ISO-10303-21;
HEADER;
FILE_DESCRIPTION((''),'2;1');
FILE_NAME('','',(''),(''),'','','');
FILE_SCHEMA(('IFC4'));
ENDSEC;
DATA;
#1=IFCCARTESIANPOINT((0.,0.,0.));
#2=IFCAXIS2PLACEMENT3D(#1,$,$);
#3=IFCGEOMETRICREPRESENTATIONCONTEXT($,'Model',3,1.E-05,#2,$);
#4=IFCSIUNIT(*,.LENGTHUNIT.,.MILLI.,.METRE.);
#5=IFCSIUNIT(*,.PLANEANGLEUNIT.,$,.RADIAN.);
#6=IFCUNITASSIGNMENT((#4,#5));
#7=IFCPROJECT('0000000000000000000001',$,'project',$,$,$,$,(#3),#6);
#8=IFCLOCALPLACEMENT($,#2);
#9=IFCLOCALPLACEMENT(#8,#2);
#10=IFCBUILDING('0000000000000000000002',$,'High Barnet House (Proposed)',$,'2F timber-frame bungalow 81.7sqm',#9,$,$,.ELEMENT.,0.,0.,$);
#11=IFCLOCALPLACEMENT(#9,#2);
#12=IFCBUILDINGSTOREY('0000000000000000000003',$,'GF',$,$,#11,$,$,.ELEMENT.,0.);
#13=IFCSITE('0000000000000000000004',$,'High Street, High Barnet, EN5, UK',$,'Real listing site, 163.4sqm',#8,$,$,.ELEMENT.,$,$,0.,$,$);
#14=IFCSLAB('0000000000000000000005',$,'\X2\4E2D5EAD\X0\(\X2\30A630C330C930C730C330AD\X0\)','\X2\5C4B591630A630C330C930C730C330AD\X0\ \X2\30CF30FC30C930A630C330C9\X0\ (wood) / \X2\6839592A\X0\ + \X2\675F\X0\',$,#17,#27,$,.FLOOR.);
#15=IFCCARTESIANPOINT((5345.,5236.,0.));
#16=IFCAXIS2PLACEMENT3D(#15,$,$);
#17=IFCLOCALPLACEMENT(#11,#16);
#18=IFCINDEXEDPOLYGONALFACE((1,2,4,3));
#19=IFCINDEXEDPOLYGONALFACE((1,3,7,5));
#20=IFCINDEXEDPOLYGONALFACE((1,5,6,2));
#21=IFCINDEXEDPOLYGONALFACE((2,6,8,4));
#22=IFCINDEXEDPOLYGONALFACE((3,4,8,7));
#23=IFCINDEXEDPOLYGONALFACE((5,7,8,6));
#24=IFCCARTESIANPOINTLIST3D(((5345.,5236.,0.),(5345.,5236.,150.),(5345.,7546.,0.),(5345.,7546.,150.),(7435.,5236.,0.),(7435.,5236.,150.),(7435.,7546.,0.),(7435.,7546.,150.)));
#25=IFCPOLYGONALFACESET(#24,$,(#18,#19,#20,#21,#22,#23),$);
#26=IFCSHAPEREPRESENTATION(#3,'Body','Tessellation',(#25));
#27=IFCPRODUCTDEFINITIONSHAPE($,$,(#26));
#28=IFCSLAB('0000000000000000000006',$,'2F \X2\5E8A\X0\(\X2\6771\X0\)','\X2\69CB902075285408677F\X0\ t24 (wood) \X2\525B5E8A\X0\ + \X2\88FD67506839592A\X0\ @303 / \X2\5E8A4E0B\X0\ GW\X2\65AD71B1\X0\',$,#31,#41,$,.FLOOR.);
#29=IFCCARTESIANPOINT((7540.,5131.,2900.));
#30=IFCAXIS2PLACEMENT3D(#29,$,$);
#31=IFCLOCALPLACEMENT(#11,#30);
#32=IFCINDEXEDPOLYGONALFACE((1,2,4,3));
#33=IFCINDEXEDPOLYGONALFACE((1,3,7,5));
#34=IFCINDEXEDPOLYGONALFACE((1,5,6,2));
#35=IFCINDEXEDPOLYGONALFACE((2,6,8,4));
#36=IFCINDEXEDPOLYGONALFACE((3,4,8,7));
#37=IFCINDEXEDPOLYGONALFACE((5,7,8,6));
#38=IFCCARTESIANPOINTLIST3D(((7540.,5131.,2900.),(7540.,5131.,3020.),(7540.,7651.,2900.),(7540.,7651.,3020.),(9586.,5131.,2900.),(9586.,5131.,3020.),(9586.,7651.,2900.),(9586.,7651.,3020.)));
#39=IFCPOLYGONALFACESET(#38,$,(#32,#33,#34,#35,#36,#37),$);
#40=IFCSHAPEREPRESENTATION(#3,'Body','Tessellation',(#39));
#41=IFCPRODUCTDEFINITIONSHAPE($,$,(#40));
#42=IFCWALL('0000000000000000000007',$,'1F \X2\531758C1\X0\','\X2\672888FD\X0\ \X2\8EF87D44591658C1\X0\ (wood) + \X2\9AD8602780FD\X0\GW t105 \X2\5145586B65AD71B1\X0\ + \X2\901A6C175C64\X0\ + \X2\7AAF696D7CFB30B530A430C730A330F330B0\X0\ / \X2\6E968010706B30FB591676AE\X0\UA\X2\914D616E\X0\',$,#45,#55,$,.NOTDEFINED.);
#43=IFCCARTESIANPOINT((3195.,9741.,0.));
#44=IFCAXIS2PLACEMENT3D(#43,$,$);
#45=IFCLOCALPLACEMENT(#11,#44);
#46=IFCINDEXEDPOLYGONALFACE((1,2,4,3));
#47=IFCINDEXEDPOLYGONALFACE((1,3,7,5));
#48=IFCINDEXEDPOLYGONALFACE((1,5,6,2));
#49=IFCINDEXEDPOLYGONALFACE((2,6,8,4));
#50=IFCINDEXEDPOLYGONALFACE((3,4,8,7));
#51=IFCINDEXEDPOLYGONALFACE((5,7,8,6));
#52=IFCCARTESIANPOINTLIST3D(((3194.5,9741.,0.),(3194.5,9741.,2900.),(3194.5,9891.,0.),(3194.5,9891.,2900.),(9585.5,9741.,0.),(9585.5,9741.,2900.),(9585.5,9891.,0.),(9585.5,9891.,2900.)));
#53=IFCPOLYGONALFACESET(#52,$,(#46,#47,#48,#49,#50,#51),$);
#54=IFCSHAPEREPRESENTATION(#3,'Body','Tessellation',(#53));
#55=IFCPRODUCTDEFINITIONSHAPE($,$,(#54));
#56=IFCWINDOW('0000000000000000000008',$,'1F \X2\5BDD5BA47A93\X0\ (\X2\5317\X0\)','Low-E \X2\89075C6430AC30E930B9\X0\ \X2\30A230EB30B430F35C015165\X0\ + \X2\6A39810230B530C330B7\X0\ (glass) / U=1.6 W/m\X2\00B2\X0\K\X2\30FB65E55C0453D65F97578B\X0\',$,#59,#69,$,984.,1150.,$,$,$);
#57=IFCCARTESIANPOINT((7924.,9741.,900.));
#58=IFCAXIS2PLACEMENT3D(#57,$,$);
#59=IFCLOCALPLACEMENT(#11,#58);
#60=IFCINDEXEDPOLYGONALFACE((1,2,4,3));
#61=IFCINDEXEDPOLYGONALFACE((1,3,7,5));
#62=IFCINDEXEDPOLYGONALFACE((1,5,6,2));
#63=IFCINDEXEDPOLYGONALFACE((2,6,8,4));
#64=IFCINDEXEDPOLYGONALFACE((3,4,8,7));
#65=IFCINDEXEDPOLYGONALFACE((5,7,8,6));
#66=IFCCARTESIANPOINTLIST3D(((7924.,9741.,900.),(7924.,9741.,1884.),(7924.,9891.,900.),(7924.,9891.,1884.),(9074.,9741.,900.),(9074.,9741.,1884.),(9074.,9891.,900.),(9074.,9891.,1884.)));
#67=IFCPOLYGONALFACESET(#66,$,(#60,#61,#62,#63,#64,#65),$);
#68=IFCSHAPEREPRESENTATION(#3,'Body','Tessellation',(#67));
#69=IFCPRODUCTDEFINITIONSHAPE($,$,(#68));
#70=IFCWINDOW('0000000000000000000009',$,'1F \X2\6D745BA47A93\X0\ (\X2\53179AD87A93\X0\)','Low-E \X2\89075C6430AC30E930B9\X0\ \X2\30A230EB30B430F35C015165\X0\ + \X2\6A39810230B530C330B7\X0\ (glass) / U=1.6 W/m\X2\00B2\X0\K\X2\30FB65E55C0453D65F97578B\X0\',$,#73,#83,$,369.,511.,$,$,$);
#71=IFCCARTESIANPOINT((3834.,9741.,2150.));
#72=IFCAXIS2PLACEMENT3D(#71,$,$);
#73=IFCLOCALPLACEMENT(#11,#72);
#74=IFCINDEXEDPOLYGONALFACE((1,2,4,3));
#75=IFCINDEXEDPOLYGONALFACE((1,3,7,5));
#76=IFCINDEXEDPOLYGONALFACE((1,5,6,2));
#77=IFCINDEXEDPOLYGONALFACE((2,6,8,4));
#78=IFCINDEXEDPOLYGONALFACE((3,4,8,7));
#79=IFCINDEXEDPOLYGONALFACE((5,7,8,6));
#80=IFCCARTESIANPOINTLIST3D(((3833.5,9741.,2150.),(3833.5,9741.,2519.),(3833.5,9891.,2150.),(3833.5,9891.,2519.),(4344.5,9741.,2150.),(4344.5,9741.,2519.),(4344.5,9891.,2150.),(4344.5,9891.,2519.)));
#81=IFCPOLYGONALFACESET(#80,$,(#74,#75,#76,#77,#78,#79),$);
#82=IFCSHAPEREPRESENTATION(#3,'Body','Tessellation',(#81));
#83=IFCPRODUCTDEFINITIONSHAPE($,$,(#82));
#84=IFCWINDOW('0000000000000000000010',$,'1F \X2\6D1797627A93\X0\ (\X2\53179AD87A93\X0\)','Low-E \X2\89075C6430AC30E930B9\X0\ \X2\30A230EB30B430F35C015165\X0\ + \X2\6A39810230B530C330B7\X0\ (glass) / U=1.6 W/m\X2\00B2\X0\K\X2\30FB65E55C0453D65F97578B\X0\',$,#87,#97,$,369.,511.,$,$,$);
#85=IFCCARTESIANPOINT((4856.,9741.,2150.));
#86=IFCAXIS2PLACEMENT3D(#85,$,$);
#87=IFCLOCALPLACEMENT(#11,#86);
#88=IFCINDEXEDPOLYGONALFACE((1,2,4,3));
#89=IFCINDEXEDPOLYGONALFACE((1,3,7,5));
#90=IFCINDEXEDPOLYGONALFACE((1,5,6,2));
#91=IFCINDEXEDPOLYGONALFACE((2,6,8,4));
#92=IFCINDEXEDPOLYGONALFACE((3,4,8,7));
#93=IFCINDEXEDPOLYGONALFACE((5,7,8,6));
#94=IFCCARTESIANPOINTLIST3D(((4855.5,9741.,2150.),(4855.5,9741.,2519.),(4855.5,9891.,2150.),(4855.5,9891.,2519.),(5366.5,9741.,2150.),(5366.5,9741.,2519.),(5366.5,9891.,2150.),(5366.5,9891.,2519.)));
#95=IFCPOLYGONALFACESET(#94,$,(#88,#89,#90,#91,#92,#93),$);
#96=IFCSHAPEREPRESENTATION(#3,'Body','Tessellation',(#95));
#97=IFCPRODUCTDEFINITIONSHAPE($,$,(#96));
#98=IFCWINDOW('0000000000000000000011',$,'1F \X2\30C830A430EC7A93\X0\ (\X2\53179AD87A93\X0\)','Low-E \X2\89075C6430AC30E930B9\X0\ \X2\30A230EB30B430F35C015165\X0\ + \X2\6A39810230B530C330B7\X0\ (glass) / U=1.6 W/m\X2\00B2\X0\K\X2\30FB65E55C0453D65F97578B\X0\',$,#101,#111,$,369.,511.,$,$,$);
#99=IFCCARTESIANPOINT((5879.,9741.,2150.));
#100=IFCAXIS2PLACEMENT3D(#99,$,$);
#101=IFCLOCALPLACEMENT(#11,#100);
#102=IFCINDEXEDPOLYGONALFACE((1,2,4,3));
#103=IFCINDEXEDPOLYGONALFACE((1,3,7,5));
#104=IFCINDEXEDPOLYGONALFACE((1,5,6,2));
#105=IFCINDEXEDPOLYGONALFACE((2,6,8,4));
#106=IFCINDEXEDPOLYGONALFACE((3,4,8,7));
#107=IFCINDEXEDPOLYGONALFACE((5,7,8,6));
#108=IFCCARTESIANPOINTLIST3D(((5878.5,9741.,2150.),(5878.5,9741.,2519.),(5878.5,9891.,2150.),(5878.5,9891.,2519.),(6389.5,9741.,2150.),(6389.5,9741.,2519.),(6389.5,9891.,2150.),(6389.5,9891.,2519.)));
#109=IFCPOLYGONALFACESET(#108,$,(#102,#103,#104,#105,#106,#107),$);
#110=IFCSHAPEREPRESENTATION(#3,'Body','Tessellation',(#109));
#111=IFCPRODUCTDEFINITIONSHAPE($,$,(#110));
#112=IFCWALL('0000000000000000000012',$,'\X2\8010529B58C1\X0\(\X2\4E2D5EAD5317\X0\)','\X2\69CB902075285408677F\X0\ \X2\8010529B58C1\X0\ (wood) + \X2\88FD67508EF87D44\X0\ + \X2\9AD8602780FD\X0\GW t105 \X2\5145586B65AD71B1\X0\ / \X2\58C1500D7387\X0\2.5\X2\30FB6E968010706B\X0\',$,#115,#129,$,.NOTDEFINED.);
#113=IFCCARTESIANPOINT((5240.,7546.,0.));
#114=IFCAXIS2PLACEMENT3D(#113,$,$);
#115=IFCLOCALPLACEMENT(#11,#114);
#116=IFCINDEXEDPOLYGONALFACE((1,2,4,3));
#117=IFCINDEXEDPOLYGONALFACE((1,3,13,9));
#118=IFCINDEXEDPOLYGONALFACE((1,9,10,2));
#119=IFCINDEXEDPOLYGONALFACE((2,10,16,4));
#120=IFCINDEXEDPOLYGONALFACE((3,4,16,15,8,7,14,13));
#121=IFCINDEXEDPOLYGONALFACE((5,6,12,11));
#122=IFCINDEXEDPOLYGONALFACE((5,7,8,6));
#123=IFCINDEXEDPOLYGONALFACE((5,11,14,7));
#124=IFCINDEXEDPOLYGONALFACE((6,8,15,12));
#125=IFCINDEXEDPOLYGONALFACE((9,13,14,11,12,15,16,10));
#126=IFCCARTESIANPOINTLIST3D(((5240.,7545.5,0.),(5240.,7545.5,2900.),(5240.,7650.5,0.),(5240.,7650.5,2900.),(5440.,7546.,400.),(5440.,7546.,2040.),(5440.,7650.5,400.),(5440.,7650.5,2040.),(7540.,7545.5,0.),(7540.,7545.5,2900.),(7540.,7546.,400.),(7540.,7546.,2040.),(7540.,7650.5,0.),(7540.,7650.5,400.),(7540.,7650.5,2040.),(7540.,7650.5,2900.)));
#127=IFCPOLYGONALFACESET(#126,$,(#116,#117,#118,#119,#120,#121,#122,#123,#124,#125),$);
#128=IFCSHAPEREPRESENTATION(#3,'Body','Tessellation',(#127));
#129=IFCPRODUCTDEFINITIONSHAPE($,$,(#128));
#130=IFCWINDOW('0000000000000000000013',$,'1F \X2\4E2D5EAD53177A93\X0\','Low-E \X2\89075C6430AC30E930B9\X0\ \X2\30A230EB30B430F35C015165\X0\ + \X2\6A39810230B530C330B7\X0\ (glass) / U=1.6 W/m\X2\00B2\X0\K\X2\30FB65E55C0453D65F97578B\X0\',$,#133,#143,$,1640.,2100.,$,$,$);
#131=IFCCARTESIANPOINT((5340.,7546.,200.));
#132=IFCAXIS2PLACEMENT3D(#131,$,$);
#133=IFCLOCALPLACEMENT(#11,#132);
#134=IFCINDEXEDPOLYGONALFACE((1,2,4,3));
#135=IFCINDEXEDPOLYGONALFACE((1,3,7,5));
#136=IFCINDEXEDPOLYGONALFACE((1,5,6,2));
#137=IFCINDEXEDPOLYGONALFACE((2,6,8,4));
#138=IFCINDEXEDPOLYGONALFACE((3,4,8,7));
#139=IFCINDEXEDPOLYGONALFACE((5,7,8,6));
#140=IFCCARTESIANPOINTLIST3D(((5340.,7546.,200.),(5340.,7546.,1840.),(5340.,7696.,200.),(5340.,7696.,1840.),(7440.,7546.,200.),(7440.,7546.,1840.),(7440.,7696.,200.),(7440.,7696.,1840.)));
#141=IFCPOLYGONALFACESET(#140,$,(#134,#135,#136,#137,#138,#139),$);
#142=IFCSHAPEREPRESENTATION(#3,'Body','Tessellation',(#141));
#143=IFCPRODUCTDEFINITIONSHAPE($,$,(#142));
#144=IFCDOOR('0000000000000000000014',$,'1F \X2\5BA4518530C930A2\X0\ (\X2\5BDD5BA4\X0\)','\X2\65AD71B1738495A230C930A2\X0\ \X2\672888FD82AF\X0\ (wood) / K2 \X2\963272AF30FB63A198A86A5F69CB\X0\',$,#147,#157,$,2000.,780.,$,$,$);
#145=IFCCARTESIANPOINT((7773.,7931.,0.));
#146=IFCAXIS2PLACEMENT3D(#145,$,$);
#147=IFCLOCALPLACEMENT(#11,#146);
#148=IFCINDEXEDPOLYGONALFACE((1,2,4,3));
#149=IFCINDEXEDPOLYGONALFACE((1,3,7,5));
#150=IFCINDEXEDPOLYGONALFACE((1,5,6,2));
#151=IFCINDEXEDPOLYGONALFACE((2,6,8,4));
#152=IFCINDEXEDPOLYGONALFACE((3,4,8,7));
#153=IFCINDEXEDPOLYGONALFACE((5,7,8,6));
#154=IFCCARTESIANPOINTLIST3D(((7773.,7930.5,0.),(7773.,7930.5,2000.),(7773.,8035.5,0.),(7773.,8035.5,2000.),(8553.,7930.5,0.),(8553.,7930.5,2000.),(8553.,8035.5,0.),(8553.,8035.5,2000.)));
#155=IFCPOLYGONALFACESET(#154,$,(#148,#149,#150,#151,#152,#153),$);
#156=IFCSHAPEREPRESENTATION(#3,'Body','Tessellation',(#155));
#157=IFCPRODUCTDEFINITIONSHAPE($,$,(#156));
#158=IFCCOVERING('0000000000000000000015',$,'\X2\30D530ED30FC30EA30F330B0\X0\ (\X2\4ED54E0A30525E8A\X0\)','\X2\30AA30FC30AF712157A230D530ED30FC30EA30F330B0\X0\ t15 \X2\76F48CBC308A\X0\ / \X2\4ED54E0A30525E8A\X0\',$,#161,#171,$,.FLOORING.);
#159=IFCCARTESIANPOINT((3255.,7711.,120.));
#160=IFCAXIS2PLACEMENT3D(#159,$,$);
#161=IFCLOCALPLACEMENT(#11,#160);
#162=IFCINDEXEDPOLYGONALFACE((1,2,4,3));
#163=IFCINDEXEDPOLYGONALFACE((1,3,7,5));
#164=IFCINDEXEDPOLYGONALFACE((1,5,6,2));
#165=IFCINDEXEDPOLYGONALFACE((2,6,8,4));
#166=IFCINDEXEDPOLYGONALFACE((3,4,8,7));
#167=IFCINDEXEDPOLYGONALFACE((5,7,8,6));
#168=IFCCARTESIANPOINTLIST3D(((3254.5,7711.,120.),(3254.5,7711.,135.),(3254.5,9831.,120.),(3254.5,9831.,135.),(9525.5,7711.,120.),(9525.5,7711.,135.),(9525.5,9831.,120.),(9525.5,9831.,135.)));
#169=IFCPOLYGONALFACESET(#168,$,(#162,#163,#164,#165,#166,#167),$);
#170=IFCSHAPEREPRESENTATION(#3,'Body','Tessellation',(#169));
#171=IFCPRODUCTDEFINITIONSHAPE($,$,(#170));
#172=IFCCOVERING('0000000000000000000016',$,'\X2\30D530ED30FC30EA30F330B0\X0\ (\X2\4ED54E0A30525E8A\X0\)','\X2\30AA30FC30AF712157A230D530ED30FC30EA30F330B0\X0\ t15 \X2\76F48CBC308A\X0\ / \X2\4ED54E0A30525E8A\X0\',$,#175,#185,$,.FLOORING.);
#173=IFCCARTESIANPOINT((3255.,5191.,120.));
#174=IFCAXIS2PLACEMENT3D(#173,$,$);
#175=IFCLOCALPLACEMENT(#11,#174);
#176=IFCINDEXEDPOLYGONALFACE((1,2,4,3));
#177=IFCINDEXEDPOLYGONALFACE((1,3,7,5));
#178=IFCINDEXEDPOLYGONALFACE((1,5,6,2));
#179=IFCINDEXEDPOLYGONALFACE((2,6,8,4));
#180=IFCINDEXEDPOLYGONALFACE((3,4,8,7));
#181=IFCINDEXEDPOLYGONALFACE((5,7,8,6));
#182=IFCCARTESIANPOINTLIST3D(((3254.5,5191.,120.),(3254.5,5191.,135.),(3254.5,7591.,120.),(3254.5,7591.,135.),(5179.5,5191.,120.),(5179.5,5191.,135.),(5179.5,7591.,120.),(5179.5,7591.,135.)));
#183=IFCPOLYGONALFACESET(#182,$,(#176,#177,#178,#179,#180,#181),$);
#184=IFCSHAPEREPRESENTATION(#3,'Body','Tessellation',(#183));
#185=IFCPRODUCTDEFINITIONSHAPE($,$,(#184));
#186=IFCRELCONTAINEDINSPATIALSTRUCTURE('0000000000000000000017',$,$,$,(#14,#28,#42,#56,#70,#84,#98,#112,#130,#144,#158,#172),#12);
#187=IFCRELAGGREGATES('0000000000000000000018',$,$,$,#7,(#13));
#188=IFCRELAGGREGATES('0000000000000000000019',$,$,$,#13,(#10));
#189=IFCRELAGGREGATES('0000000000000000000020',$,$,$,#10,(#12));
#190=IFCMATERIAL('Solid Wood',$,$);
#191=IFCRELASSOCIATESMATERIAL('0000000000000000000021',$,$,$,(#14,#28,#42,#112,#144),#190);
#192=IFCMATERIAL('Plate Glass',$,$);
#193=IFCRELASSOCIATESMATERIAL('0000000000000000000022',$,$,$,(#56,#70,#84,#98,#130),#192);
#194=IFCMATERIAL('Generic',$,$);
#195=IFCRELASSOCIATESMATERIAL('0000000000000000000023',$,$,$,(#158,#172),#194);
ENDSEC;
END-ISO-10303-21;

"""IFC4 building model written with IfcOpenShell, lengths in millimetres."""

from ifc_helpers import new_model, si_unit, frame, frame_2d, origin, place, context, project, spatial, rectangle, extrude, material, element, fill, save


model = new_model("IFC4")

# Units and contexts
model_context = context("Model", 3, precision=1e-05, world=origin())
ifc_project = project(units=[si_unit("LENGTHUNIT", "METRE", prefix="MILLI"), si_unit("PLANEANGLEUNIT", "RADIAN")], contexts=[model_context])

# Site, building, storey
site_placement = place(None, origin())
site = spatial("IfcSite", under=ifc_project, at=site_placement, Name="High Street, High Barnet, EN5, UK", ObjectType="Real listing site, 163.4sqm", CompositionType="ELEMENT", RefElevation=0.0)
building_placement = place(site_placement, origin())
building = spatial("IfcBuilding", under=site, at=building_placement, Name="High Barnet House (Proposed)", ObjectType="2F timber-frame bungalow 81.7sqm", CompositionType="ELEMENT", ElevationOfRefHeight=0.0, ElevationOfTerrain=0.0)
storey_placement = place(building_placement, origin())
storey = spatial("IfcBuildingStorey", under=building, at=storey_placement, Name="GF", CompositionType="ELEMENT", Elevation=0.0)

# Slabs
ifc_material_1 = material(Name="Solid Wood")
slab_1_placement = place(storey_placement, frame((5345.0, 5236.0, 0.0)))
element("IfcSlab", 1, at=slab_1_placement, inside=storey, material=ifc_material_1, Name="中庭(ウッドデッキ)", Description="屋外ウッドデッキ ハードウッド (wood) / 根太 + 束", PredefinedType="FLOOR", context=model_context, shape_type="SweptSolid", body=[
    extrude(rectangle(XDim=2090.0, YDim=2310.0, at=frame_2d((1045.0, 1155.0))), frame((5345.0, 5236.0, 0.0)), (0.0, 0.0, 1.0), 150.0),
])
slab_2_placement = place(storey_placement, frame((7540.0, 5131.0, 2900.0)))
element("IfcSlab", 2, at=slab_2_placement, inside=storey, material=ifc_material_1, Name="2F 床(東)", Description="構造用合板 t24 (wood) 剛床 + 製材根太 @303 / 床下 GW断熱", PredefinedType="FLOOR", context=model_context, shape_type="SweptSolid", body=[
    extrude(rectangle(XDim=2046.0, YDim=2520.0, at=frame_2d((1023.0, 1260.0))), frame((7540.0, 5131.0, 2900.0)), (0.0, 0.0, 1.0), 120.0),
])

# Wall, openings, windows
wall_1_placement = place(storey_placement, frame((3195.0, 9741.0, 0.0)))
wall_1 = element("IfcWall", 3, at=wall_1_placement, inside=storey, material=ifc_material_1, Name="1F 北壁", Description="木製 軸組外壁 (wood) + 高性能GW t105 充填断熱 + 通気層 + 窯業系サイディング / 準耐火・外皮UA配慮", PredefinedType="NOTDEFINED", context=model_context, shape_type="SweptSolid", body=[
    extrude(rectangle(XDim=6391.0, YDim=150.0, at=frame_2d((3195.0, 75.0))), frame((3195.0, 9741.0, 0.0)), (0.0, 0.0, 1.0), 2900.0),
])
opening_1_placement = place(storey_placement, frame((7924.0, 9741.0, 900.0)))
opening_1 = element("IfcOpeningElement", 4, at=opening_1_placement, cuts=wall_1, PredefinedType="NOTDEFINED", context=model_context, shape_type="SweptSolid", body=[
    extrude(rectangle(XDim=1150.0, YDim=150.0, at=frame_2d((575.0, 75.0))), frame((7924.0, 9741.0, 900.0)), (0.0, 0.0, 1.0), 984.0),
])
opening_2_placement = place(storey_placement, frame((3834.0, 9741.0, 2150.0)))
opening_2 = element("IfcOpeningElement", 5, at=opening_2_placement, cuts=wall_1, PredefinedType="NOTDEFINED", context=model_context, shape_type="SweptSolid", body=[
    extrude(rectangle(XDim=511.0, YDim=150.0, at=frame_2d((255.0, 75.0))), frame((3834.0, 9741.0, 2150.0)), (0.0, 0.0, 1.0), 369.0),
])
opening_3_placement = place(storey_placement, frame((4856.0, 9741.0, 2150.0)))
opening_3 = element("IfcOpeningElement", 6, at=opening_3_placement, cuts=wall_1, PredefinedType="NOTDEFINED", context=model_context, shape_type="SweptSolid", body=[
    extrude(rectangle(XDim=511.0, YDim=150.0, at=frame_2d((255.0, 75.0))), frame((4856.0, 9741.0, 2150.0)), (0.0, 0.0, 1.0), 369.0),
])
opening_4_placement = place(storey_placement, frame((5879.0, 9741.0, 2150.0)))
opening_4 = element("IfcOpeningElement", 7, at=opening_4_placement, cuts=wall_1, PredefinedType="NOTDEFINED", context=model_context, shape_type="SweptSolid", body=[
    extrude(rectangle(XDim=511.0, YDim=150.0, at=frame_2d((255.0, 75.0))), frame((5879.0, 9741.0, 2150.0)), (0.0, 0.0, 1.0), 369.0),
])
ifc_material_2 = material(Name="Plate Glass")
window_1_placement = place(storey_placement, frame((7924.0, 9741.0, 900.0)))
window_1 = element("IfcWindow", 8, at=window_1_placement, inside=storey, material=ifc_material_2, Name="1F 寝室窓 (北)", Description="Low-E 複層ガラス アルゴン封入 + 樹脂サッシ (glass) / U=1.6 W/m²K・日射取得型", OverallHeight=984.0, OverallWidth=1150.0, context=model_context, shape_type="SweptSolid", body=[
    extrude(rectangle(XDim=1150.0, YDim=150.0, at=frame_2d((575.0, 75.0))), frame((7924.0, 9741.0, 900.0)), (0.0, 0.0, 1.0), 984.0),
])
fill(opening_1, window_1)
window_2_placement = place(storey_placement, frame((3834.0, 9741.0, 2150.0)))
window_2 = element("IfcWindow", 9, at=window_2_placement, inside=storey, material=ifc_material_2, Name="1F 浴室窓 (北高窓)", Description="Low-E 複層ガラス アルゴン封入 + 樹脂サッシ (glass) / U=1.6 W/m²K・日射取得型", OverallHeight=369.0, OverallWidth=511.0, context=model_context, shape_type="SweptSolid", body=[
    extrude(rectangle(XDim=511.0, YDim=150.0, at=frame_2d((255.0, 75.0))), frame((3834.0, 9741.0, 2150.0)), (0.0, 0.0, 1.0), 369.0),
])
fill(opening_2, window_2)
window_3_placement = place(storey_placement, frame((4856.0, 9741.0, 2150.0)))
window_3 = element("IfcWindow", 10, at=window_3_placement, inside=storey, material=ifc_material_2, Name="1F 洗面窓 (北高窓)", Description="Low-E 複層ガラス アルゴン封入 + 樹脂サッシ (glass) / U=1.6 W/m²K・日射取得型", OverallHeight=369.0, OverallWidth=511.0, context=model_context, shape_type="SweptSolid", body=[
    extrude(rectangle(XDim=511.0, YDim=150.0, at=frame_2d((255.0, 75.0))), frame((4856.0, 9741.0, 2150.0)), (0.0, 0.0, 1.0), 369.0),
])
fill(opening_3, window_3)
window_4_placement = place(storey_placement, frame((5879.0, 9741.0, 2150.0)))
window_4 = element("IfcWindow", 11, at=window_4_placement, inside=storey, material=ifc_material_2, Name="1F トイレ窓 (北高窓)", Description="Low-E 複層ガラス アルゴン封入 + 樹脂サッシ (glass) / U=1.6 W/m²K・日射取得型", OverallHeight=369.0, OverallWidth=511.0, context=model_context, shape_type="SweptSolid", body=[
    extrude(rectangle(XDim=511.0, YDim=150.0, at=frame_2d((255.0, 75.0))), frame((5879.0, 9741.0, 2150.0)), (0.0, 0.0, 1.0), 369.0),
])
fill(opening_4, window_4)

# Wall, opening, window
wall_2_placement = place(storey_placement, frame((5240.0, 7546.0, 0.0)))
wall_2 = element("IfcWall", 12, at=wall_2_placement, inside=storey, material=ifc_material_1, Name="耐力壁(中庭北)", Description="構造用合板 耐力壁 (wood) + 製材軸組 + 高性能GW t105 充填断熱 / 壁倍率2.5・準耐火", PredefinedType="NOTDEFINED", context=model_context, shape_type="SweptSolid", body=[
    extrude(rectangle(XDim=2300.0, YDim=105.0, at=frame_2d((1150.0, 52.0))), frame((5240.0, 7546.0, 0.0)), (0.0, 0.0, 1.0), 2900.0),
])
opening_5_placement = place(storey_placement, frame((5340.0, 7546.0, 200.0)))
opening_5 = element("IfcOpeningElement", 13, at=opening_5_placement, cuts=wall_2, PredefinedType="NOTDEFINED", context=model_context, shape_type="SweptSolid", body=[
    extrude(rectangle(XDim=2100.0, YDim=150.0, at=frame_2d((1050.0, 75.0))), frame((5340.0, 7546.0, 200.0)), (0.0, 0.0, 1.0), 1640.0),
])
window_5_placement = place(storey_placement, frame((5340.0, 7546.0, 200.0)))
window_5 = element("IfcWindow", 14, at=window_5_placement, inside=storey, material=ifc_material_2, Name="1F 中庭北窓", Description="Low-E 複層ガラス アルゴン封入 + 樹脂サッシ (glass) / U=1.6 W/m²K・日射取得型", OverallHeight=1640.0, OverallWidth=2100.0, context=model_context, shape_type="SweptSolid", body=[
    extrude(rectangle(XDim=2100.0, YDim=150.0, at=frame_2d((1050.0, 75.0))), frame((5340.0, 7546.0, 200.0)), (0.0, 0.0, 1.0), 1640.0),
])
fill(opening_5, window_5)

# Door
door_1_placement = place(storey_placement, frame((7773.0, 7931.0, 0.0)))
element("IfcDoor", 15, at=door_1_placement, inside=storey, material=ifc_material_1, Name="1F 室内ドア (寝室)", Description="断熱玄関ドア 木製芯 (wood) / K2 防犯・採風機構", OverallHeight=2000.0, OverallWidth=780.0, context=model_context, shape_type="SweptSolid", body=[
    extrude(rectangle(XDim=780.0, YDim=105.0, at=frame_2d((390.0, 52.0))), frame((7773.0, 7931.0, 0.0)), (0.0, 0.0, 1.0), 2000.0),
])

# Coverings
ifc_material_3 = material(Name="Generic")
covering_1_placement = place(storey_placement, frame((3255.0, 7711.0, 120.0)))
element("IfcCovering", 16, at=covering_1_placement, inside=storey, material=ifc_material_3, Name="フローリング (仕上げ床)", Description="オーク無垢フローリング t15 直貼り / 仕上げ床", PredefinedType="FLOORING", context=model_context, shape_type="SweptSolid", body=[
    extrude(rectangle(XDim=6271.0, YDim=2120.0, at=frame_2d((3135.0, 1060.0))), frame((3255.0, 7711.0, 120.0)), (0.0, 0.0, 1.0), 15.0),
])
covering_2_placement = place(storey_placement, frame((3255.0, 5191.0, 120.0)))
element("IfcCovering", 17, at=covering_2_placement, inside=storey, material=ifc_material_3, Name="フローリング (仕上げ床)", Description="オーク無垢フローリング t15 直貼り / 仕上げ床", PredefinedType="FLOORING", context=model_context, shape_type="SweptSolid", body=[
    extrude(rectangle(XDim=1925.0, YDim=2400.0, at=frame_2d((962.0, 1200.0))), frame((3255.0, 5191.0, 120.0)), (0.0, 0.0, 1.0), 15.0),
])

save(model, "model.ifc")
